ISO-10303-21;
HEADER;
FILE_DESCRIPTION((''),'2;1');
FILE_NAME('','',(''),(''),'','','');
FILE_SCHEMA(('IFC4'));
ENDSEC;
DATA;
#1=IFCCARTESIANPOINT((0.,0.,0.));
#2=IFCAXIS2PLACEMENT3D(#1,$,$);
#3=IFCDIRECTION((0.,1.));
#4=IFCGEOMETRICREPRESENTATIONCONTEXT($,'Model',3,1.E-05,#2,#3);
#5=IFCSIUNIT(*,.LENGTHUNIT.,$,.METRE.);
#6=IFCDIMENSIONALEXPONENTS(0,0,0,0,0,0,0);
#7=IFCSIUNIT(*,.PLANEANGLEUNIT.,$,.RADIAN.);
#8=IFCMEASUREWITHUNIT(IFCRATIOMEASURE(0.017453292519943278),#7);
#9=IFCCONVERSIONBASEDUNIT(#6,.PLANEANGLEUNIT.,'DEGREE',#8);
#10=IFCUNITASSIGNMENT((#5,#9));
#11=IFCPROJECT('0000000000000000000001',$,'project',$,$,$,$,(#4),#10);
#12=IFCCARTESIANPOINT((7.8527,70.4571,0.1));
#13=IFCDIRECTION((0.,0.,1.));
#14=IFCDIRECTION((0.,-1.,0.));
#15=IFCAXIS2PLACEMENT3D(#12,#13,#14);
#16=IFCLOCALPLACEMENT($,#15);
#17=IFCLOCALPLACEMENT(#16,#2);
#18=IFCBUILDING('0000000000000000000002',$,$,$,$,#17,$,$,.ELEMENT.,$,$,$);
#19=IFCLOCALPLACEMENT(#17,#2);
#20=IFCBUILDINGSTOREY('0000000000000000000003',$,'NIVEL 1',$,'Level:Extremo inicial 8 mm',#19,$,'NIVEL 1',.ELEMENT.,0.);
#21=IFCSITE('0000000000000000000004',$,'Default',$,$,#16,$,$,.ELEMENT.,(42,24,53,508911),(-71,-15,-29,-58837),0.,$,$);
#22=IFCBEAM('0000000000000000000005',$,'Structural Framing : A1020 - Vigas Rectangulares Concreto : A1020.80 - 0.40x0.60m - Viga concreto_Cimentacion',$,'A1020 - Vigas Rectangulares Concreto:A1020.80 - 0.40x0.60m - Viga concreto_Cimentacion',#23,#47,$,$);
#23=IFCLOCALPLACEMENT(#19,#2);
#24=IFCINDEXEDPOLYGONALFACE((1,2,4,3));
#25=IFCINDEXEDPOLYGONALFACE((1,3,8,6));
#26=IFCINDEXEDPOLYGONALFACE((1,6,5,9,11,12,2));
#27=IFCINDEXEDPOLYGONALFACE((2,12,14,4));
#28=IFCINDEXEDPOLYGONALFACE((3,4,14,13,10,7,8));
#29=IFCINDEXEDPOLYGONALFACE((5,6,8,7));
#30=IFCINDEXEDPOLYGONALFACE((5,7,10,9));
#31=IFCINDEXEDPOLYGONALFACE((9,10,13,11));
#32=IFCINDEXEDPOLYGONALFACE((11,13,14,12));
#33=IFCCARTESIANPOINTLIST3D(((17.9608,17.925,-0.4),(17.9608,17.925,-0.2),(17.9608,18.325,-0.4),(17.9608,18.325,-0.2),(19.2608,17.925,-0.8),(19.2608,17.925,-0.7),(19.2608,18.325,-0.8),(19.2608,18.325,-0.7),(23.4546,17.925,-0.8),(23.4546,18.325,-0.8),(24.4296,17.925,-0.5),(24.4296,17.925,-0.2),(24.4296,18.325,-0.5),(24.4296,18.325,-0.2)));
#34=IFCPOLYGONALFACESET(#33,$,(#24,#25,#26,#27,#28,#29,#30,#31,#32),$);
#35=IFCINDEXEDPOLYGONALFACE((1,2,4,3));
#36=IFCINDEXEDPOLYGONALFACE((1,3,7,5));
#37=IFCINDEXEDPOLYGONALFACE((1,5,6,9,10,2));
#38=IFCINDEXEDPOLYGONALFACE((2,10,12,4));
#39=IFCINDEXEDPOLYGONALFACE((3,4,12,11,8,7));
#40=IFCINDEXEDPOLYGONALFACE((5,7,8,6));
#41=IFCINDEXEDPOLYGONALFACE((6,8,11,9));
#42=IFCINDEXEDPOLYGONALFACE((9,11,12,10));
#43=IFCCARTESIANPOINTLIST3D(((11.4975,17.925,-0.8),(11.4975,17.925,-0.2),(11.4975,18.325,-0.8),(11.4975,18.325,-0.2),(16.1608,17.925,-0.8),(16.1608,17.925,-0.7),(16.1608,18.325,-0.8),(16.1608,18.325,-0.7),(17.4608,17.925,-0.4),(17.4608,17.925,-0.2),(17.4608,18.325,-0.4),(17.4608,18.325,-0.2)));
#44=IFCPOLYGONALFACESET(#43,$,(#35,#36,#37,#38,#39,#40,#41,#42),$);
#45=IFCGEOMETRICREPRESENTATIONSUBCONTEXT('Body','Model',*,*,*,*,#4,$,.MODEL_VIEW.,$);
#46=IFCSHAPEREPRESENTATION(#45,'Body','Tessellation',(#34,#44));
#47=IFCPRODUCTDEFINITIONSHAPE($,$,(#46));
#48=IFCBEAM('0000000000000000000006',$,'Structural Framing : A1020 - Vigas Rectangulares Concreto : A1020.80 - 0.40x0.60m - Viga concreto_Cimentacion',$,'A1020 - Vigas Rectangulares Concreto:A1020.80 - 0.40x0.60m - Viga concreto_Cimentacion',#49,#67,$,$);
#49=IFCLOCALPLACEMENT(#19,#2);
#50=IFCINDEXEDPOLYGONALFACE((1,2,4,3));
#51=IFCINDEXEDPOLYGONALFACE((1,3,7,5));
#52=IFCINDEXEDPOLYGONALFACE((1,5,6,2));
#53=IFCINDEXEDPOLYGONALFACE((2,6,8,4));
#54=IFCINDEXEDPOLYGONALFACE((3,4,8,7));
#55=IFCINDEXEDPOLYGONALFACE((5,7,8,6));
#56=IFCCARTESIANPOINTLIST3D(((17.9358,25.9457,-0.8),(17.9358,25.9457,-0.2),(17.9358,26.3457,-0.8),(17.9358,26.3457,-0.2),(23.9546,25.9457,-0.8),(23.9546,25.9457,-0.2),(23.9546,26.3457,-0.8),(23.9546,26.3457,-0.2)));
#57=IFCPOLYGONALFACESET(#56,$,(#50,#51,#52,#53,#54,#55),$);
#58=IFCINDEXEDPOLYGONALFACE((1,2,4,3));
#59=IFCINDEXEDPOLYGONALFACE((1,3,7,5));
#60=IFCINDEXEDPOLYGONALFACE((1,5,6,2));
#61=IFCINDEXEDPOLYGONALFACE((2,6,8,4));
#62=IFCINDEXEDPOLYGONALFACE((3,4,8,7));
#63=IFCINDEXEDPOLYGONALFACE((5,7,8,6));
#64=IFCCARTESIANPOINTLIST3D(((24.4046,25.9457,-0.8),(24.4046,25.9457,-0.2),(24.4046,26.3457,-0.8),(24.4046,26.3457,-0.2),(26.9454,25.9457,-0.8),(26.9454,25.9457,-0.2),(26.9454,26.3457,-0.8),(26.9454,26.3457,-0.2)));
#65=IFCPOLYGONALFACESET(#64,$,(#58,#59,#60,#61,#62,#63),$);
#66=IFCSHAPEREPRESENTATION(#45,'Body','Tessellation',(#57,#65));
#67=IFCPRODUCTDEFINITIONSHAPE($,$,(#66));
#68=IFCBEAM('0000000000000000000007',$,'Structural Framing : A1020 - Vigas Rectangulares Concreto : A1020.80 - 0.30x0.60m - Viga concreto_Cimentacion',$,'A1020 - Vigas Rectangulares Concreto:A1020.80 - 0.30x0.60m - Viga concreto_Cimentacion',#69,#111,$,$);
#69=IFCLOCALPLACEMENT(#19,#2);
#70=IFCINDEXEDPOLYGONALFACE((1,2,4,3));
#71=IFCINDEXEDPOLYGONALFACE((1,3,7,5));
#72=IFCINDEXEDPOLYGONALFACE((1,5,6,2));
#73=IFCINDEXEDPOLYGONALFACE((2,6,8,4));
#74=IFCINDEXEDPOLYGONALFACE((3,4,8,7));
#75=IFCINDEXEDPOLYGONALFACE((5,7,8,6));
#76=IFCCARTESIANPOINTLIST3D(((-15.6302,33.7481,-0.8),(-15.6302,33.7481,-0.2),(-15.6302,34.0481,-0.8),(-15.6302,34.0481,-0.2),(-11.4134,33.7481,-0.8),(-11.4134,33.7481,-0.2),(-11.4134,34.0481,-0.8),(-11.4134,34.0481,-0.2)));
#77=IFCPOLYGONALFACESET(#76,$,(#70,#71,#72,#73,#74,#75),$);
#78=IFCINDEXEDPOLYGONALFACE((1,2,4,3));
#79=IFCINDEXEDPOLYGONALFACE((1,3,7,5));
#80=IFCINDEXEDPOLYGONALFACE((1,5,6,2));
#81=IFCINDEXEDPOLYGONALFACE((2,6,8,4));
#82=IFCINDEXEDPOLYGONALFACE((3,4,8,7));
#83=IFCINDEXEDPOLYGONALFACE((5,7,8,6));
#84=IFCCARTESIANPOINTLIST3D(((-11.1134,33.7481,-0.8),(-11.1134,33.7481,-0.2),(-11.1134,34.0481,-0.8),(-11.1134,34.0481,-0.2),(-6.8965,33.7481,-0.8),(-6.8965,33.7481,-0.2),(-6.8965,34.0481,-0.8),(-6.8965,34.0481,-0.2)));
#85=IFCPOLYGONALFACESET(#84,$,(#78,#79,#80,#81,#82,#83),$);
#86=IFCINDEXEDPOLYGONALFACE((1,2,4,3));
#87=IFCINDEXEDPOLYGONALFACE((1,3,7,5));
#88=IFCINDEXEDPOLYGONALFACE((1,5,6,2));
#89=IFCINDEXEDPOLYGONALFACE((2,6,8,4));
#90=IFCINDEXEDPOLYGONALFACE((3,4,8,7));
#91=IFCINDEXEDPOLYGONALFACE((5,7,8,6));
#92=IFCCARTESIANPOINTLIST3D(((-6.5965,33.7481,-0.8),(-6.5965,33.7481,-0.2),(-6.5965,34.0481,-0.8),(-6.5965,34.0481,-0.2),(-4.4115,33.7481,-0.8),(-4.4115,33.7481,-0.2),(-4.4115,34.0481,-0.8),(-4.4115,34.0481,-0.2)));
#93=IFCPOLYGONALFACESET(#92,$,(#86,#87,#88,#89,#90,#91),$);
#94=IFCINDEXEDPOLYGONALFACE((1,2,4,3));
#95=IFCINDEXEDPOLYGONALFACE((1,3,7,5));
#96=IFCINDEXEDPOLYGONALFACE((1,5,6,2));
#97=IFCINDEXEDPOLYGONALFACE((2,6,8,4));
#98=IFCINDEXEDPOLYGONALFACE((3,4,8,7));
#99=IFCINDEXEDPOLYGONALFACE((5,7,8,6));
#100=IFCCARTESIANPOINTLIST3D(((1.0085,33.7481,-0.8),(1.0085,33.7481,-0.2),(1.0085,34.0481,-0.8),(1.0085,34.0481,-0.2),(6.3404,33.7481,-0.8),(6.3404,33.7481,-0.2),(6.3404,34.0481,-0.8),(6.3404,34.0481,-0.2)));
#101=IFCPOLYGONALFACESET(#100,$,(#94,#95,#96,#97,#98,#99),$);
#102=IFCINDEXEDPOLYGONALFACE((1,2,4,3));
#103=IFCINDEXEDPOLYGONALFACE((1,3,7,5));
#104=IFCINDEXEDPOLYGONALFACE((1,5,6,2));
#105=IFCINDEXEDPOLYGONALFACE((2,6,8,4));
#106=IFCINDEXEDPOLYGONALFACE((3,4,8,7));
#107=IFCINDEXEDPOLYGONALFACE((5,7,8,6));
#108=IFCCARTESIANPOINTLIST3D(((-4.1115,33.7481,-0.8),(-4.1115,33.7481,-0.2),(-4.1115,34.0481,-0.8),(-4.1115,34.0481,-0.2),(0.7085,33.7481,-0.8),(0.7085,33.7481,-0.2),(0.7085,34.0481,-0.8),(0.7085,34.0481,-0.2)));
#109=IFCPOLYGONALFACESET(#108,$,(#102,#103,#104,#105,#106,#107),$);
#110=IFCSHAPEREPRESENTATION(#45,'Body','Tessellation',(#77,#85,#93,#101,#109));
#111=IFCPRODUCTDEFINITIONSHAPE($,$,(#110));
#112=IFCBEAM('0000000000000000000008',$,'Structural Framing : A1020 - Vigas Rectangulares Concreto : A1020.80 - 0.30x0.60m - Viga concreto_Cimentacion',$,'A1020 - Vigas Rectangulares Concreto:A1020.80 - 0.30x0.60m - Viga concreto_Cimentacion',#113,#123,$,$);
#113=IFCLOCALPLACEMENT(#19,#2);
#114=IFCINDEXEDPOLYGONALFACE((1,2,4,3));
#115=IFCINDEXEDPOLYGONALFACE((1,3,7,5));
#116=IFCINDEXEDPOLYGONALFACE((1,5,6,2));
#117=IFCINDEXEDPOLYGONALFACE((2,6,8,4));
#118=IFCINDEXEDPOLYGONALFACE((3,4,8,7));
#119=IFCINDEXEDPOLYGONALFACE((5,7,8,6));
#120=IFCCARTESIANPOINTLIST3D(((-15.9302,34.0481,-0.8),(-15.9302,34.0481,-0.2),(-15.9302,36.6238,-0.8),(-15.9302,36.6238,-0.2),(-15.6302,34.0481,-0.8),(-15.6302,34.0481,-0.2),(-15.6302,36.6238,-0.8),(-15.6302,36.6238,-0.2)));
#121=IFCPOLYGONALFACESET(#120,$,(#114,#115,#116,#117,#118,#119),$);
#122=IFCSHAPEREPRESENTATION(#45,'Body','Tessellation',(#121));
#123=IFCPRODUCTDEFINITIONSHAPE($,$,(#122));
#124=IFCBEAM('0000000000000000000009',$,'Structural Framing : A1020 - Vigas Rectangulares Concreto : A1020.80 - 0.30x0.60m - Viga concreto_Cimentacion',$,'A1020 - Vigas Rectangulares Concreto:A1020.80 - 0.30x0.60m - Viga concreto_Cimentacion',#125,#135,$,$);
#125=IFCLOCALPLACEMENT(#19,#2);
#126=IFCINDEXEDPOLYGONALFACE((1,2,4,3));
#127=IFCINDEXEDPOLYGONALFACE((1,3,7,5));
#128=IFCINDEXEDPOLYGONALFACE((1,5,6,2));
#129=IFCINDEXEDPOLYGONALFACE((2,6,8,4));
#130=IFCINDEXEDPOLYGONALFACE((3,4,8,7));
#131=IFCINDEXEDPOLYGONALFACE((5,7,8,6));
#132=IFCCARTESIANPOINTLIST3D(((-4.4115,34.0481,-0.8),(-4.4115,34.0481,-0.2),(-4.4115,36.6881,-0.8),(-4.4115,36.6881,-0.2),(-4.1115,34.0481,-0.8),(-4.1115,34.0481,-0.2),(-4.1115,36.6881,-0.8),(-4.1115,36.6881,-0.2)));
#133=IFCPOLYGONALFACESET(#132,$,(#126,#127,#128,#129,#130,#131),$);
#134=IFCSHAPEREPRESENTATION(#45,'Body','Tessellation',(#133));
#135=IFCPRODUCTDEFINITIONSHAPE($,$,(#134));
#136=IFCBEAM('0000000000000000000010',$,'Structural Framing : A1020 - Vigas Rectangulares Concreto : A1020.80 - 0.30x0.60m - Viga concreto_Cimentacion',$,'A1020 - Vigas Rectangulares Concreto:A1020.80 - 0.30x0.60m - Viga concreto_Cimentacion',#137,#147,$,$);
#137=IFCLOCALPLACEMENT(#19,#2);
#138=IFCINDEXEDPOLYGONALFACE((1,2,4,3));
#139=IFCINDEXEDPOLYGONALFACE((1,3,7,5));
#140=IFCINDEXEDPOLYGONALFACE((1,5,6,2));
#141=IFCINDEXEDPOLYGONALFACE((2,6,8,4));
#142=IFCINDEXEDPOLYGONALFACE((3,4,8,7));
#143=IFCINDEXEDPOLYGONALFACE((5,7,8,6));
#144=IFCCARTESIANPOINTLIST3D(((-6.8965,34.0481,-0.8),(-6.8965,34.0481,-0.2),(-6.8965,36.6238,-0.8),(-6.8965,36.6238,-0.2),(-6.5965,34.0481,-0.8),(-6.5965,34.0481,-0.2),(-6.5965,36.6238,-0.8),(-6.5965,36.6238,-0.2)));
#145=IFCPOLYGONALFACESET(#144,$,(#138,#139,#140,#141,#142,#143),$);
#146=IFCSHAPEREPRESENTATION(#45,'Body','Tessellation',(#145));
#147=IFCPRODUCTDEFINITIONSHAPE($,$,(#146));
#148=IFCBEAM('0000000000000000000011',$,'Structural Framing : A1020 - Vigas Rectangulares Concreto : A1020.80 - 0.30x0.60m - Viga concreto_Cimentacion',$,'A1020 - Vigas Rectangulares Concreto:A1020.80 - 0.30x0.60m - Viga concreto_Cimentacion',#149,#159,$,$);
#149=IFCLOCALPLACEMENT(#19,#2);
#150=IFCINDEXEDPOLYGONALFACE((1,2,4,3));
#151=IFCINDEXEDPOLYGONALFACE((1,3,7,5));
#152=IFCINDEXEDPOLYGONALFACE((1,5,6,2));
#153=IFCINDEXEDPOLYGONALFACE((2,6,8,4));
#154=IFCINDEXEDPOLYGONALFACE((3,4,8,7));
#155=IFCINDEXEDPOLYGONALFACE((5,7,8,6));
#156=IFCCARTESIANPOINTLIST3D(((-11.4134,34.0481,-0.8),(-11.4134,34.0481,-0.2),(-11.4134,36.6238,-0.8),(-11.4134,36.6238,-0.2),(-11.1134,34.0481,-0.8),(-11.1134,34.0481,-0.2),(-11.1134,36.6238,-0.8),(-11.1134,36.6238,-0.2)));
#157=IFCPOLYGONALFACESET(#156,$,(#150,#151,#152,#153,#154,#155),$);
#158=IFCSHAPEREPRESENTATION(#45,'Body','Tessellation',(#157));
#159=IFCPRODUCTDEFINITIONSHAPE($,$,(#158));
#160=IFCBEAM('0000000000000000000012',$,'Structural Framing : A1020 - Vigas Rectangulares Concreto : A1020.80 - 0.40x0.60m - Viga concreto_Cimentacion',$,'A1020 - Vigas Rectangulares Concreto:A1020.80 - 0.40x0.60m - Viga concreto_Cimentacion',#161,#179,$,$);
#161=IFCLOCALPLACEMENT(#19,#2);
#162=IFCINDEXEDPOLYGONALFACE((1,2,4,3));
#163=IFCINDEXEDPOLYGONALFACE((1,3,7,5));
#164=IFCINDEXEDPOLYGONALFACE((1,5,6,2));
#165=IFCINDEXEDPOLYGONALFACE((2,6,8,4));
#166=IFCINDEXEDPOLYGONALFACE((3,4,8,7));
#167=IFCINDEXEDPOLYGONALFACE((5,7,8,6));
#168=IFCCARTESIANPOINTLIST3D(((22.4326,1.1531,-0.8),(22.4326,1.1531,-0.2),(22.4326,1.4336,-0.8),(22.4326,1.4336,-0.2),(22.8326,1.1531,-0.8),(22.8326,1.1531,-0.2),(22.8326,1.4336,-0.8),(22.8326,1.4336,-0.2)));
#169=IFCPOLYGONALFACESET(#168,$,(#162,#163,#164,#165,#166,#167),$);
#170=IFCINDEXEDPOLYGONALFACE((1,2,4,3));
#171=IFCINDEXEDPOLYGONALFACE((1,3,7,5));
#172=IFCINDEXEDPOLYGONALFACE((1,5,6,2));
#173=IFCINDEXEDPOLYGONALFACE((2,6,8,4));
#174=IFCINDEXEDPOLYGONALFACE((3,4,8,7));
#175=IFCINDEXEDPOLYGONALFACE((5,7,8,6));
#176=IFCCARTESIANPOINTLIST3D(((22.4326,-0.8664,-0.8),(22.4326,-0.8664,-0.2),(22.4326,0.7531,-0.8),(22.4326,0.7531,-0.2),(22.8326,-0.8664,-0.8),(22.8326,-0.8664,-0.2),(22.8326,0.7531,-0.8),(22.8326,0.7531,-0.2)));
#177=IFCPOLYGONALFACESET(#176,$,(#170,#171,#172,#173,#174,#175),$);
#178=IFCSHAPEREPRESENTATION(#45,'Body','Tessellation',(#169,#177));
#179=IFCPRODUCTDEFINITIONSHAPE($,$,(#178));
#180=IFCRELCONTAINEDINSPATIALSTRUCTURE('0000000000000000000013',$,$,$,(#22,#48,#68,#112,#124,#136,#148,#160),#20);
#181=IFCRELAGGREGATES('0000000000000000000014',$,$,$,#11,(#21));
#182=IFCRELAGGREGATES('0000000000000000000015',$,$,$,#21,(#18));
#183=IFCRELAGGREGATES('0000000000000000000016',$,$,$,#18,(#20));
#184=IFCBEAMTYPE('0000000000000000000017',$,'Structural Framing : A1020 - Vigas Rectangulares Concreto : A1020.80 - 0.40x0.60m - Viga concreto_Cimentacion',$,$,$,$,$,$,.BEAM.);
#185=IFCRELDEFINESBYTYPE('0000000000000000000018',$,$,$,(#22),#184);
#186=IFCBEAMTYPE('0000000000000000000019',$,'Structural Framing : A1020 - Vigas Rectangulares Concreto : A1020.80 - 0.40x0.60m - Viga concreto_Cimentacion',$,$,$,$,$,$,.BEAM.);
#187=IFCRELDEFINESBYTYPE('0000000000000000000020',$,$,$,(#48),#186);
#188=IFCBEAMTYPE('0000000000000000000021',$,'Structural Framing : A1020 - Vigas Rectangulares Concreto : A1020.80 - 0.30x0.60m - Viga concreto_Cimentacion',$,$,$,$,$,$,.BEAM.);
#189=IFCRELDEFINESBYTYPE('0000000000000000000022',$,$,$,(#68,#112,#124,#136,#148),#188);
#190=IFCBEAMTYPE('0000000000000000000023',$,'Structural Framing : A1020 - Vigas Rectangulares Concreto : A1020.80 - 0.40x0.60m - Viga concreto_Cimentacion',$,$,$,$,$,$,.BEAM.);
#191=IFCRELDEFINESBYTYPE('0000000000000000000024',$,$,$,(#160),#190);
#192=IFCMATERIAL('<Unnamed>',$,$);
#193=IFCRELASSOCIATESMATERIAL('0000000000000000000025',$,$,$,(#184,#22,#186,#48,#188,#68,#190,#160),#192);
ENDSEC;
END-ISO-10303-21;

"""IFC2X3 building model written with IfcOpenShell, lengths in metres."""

from ifc_helpers import new_model, entity, si_unit, converted_unit, direction, frame, frame_2d, origin, place, context, subcontext, project, spatial, polyline, rectangle, extrude, clip, halfspace, bounded_halfspace, source, transform, mapped, material, type_object, type_shapes, element, save


model = new_model("IFC2X3")

# Units and contexts
model_context = context("Model", 3, precision=1e-05, world=origin(), true_north=direction((0.0, 1.0)))
body_context = subcontext(model_context, "Body", "Model", "MODEL_VIEW")
ifc_project = project(units=[si_unit("LENGTHUNIT", "METRE"), converted_unit("PLANEANGLEUNIT", "DEGREE", entity("IfcRatioMeasure", 0.017453292519943278), si_unit("PLANEANGLEUNIT", "RADIAN"), dimensions=[0, 0, 0, 0, 0, 0, 0])], contexts=[model_context])

# Site, building, storey
site_placement = place(None, frame((7.8527, 70.4571, 0.1), z_axis=(0.0, 0.0, 1.0), x_axis=(0.0, -1.0, 0.0)))
site = spatial("IfcSite", under=ifc_project, at=site_placement, Name="Default", CompositionType="ELEMENT", RefLatitude=(42, 24, 53, 508911), RefLongitude=(-71, -15, -29, -58837), RefElevation=0.0)
building_placement = place(site_placement, origin())
building = spatial("IfcBuilding", under=site, at=building_placement, CompositionType="ELEMENT")
storey_placement = place(building_placement, origin())
storey = spatial("IfcBuildingStorey", under=building, at=storey_placement, Name="NIVEL 1", ObjectType="Level:Extremo inicial 8 mm", LongName="NIVEL 1", CompositionType="ELEMENT", Elevation=0.0)

# Shared definitions
ifc_material_1 = material(Name="<Unnamed>")

# Beams
beam_type_1 = type_object("IfcBeamType", Name="Structural Framing : A1020 - Vigas Rectangulares Concreto : A1020.80 - 0.40x0.60m - Viga concreto_Cimentacion", PredefinedType="BEAM", material=ifc_material_1)
shared_shape_1 = source(origin(), body_context, "Body", "SweptSolid", [
    clip(clip(clip(extrude(rectangle(XDim=0.6, YDim=0.4, at=frame_2d((0.0, 0.0), x_axis=(0.0, 1.0))), frame((17.9608, 18.125, -0.5), z_axis=(1.0, 0.0, 0.0), x_axis=(0.0, 1.0, 0.0)), (0.0, 0.0, 1.0), 6.4688), halfspace(frame((23.4546, 18.125, -0.8), z_axis=(0.294086, 0.0, -0.955779), x_axis=(0.0, -1.0, 0.0)), False)), bounded_halfspace(frame((19.2608, 18.125, -0.7), z_axis=(-0.22486, 0.0, -0.974391), x_axis=(0.0, 1.0, 0.0)), False, frame((17.9608, 18.125, -0.5), z_axis=(1.0, 0.0, 0.0), x_axis=(0.0, 1.0, 0.0)), polyline([(-0.2, -0.2), (-0.2, 0.1), (0.2, 0.1), (0.2, -0.2), (-0.2, -0.2)]))), bounded_halfspace(frame((19.2608, 16.575, -0.7), z_axis=(-1.0, 0.0, 0.0), x_axis=(0.0, 0.0, -1.0)), False, frame((17.9608, 18.125, -0.5), z_axis=(1.0, 0.0, 0.0), x_axis=(0.0, 1.0, 0.0)), polyline([(-0.2, -0.3), (-0.2, -0.2), (0.2, -0.2), (0.2, -0.3), (-0.2, -0.3)]))),
    clip(clip(extrude(rectangle(XDim=0.6, YDim=0.4, at=frame_2d((0.0, 0.0), x_axis=(0.0, 1.0))), frame((11.4975, 18.125, -0.5), z_axis=(1.0, 0.0, 0.0), x_axis=(0.0, 1.0, 0.0)), (0.0, 0.0, 1.0), 5.9633), bounded_halfspace(frame((16.1608, 18.125, -0.7), z_axis=(0.22486, 0.0, -0.974391), x_axis=(0.0, -1.0, 0.0)), False, frame((11.4975, 18.125, -0.5), z_axis=(1.0, 0.0, 0.0), x_axis=(0.0, 1.0, 0.0)), polyline([(-0.2, 0.1), (-0.2, -0.2), (0.2, -0.2), (0.2, 0.1), (-0.2, 0.1)]))), bounded_halfspace(frame((16.1608, 19.675, -0.7), z_axis=(1.0, 0.0, 0.0), x_axis=(0.0, 0.0, -1.0)), False, frame((11.4975, 18.125, -0.5), z_axis=(1.0, 0.0, 0.0), x_axis=(0.0, 1.0, 0.0)), polyline([(-0.2, -0.2), (-0.2, -0.3), (0.2, -0.3), (0.2, -0.2), (-0.2, -0.2)]))),
])
type_shapes(beam_type_1, [shared_shape_1])
beam_1_placement = place(storey_placement, origin())
element("IfcBeam", 1, at=beam_1_placement, inside=storey, type_object=beam_type_1, material=ifc_material_1, Name="Structural Framing : A1020 - Vigas Rectangulares Concreto : A1020.80 - 0.40x0.60m - Viga concreto_Cimentacion", ObjectType="A1020 - Vigas Rectangulares Concreto:A1020.80 - 0.40x0.60m - Viga concreto_Cimentacion", context=body_context, shape_type="MappedRepresentation", body=[
    mapped(shared_shape_1, transform((0.0, 0.0, 0.0), scale=1.0)),
])
beam_type_2 = type_object("IfcBeamType", Name="Structural Framing : A1020 - Vigas Rectangulares Concreto : A1020.80 - 0.40x0.60m - Viga concreto_Cimentacion", PredefinedType="BEAM", material=ifc_material_1)
shared_shape_2 = source(origin(), body_context, "Body", "SweptSolid", [
    extrude(rectangle(XDim=0.6, YDim=0.4, at=frame_2d((0.0, 0.0), x_axis=(1.0, 0.0))), frame((17.9358, 26.1457, -0.5), z_axis=(1.0, 0.0, 0.0), x_axis=(0.0, 0.0, -1.0)), (0.0, 0.0, 1.0), 6.0188),
    extrude(rectangle(XDim=0.6, YDim=0.4, at=frame_2d((0.0, 0.0), x_axis=(1.0, 0.0))), frame((24.4046, 26.1457, -0.5), z_axis=(1.0, 0.0, 0.0), x_axis=(0.0, 0.0, -1.0)), (0.0, 0.0, 1.0), 2.5408),
])
type_shapes(beam_type_2, [shared_shape_2])
beam_2_placement = place(storey_placement, origin())
element("IfcBeam", 2, at=beam_2_placement, inside=storey, type_object=beam_type_2, material=ifc_material_1, Name="Structural Framing : A1020 - Vigas Rectangulares Concreto : A1020.80 - 0.40x0.60m - Viga concreto_Cimentacion", ObjectType="A1020 - Vigas Rectangulares Concreto:A1020.80 - 0.40x0.60m - Viga concreto_Cimentacion", context=body_context, shape_type="MappedRepresentation", body=[
    mapped(shared_shape_2, transform((0.0, 0.0, 0.0), scale=1.0)),
])
beam_type_3 = type_object("IfcBeamType", Name="Structural Framing : A1020 - Vigas Rectangulares Concreto : A1020.80 - 0.30x0.60m - Viga concreto_Cimentacion", PredefinedType="BEAM", material=ifc_material_1)
shared_shape_3 = source(origin(), body_context, "Body", "SweptSolid", [
    extrude(rectangle(XDim=0.6, YDim=0.3, at=frame_2d((0.0, 0.0), x_axis=(1.0, 0.0))), frame((-15.6302, 33.8981, -0.5), z_axis=(1.0, 0.0, 0.0), x_axis=(0.0, 0.0, -1.0)), (0.0, 0.0, 1.0), 4.2168),
    extrude(rectangle(XDim=0.6, YDim=0.3, at=frame_2d((0.0, 0.0), x_axis=(1.0, 0.0))), frame((-11.1134, 33.8981, -0.5), z_axis=(1.0, 0.0, 0.0), x_axis=(0.0, 0.0, -1.0)), (0.0, 0.0, 1.0), 4.2168),
    extrude(rectangle(XDim=0.6, YDim=0.3, at=frame_2d((0.0, 0.0), x_axis=(1.0, 0.0))), frame((-6.5965, 33.8981, -0.5), z_axis=(1.0, 0.0, 0.0), x_axis=(0.0, 0.0, -1.0)), (0.0, 0.0, 1.0), 2.185),
    extrude(rectangle(XDim=0.6, YDim=0.3, at=frame_2d((0.0, 0.0), x_axis=(1.0, 0.0))), frame((1.0085, 33.8981, -0.5), z_axis=(1.0, 0.0, 0.0), x_axis=(0.0, 0.0, -1.0)), (0.0, 0.0, 1.0), 5.3319),
    extrude(rectangle(XDim=0.6, YDim=0.3, at=frame_2d((0.0, 0.0), x_axis=(1.0, 0.0))), frame((-4.1115, 33.8981, -0.5), z_axis=(1.0, 0.0, 0.0), x_axis=(0.0, 0.0, -1.0)), (0.0, 0.0, 1.0), 4.82),
])
type_shapes(beam_type_3, [shared_shape_3])
beam_3_placement = place(storey_placement, origin())
element("IfcBeam", 3, at=beam_3_placement, inside=storey, type_object=beam_type_3, material=ifc_material_1, Name="Structural Framing : A1020 - Vigas Rectangulares Concreto : A1020.80 - 0.30x0.60m - Viga concreto_Cimentacion", ObjectType="A1020 - Vigas Rectangulares Concreto:A1020.80 - 0.30x0.60m - Viga concreto_Cimentacion", context=body_context, shape_type="MappedRepresentation", body=[
    mapped(shared_shape_3, transform((0.0, 0.0, 0.0), scale=1.0)),
])
beam_4_placement = place(storey_placement, frame((-15.7802, 33.8981, 0.0), z_axis=(0.0, 0.0, 1.0), x_axis=(0.0, 1.0, 0.0)))
element("IfcBeam", 4, at=beam_4_placement, inside=storey, type_object=beam_type_3, Name="Structural Framing : A1020 - Vigas Rectangulares Concreto : A1020.80 - 0.30x0.60m - Viga concreto_Cimentacion", ObjectType="A1020 - Vigas Rectangulares Concreto:A1020.80 - 0.30x0.60m - Viga concreto_Cimentacion", context=body_context, shape_type="SweptSolid", body=[
    extrude(rectangle(XDim=0.6, YDim=0.3, at=frame_2d((0.0, 0.0), x_axis=(1.0, 0.0))), frame((0.15, 0.0, -0.5), z_axis=(1.0, 0.0, 0.0), x_axis=(0.0, 0.0, -1.0)), (0.0, 0.0, 1.0), 2.5757),
])
beam_5_placement = place(storey_placement, frame((-4.2615, 33.8981, 0.0), z_axis=(0.0, 0.0, 1.0), x_axis=(0.0, 1.0, 0.0)))
element("IfcBeam", 5, at=beam_5_placement, inside=storey, type_object=beam_type_3, Name="Structural Framing : A1020 - Vigas Rectangulares Concreto : A1020.80 - 0.30x0.60m - Viga concreto_Cimentacion", ObjectType="A1020 - Vigas Rectangulares Concreto:A1020.80 - 0.30x0.60m - Viga concreto_Cimentacion", context=body_context, shape_type="SweptSolid", body=[
    extrude(rectangle(XDim=0.6, YDim=0.3, at=frame_2d((0.0, 0.0), x_axis=(1.0, 0.0))), frame((0.15, 0.0, -0.5), z_axis=(1.0, 0.0, 0.0), x_axis=(0.0, 0.0, -1.0)), (0.0, 0.0, 1.0), 2.6399),
])
beam_6_placement = place(storey_placement, frame((-6.7465, 33.8981, 0.0), z_axis=(0.0, 0.0, 1.0), x_axis=(0.0, 1.0, 0.0)))
element("IfcBeam", 6, at=beam_6_placement, inside=storey, type_object=beam_type_3, Name="Structural Framing : A1020 - Vigas Rectangulares Concreto : A1020.80 - 0.30x0.60m - Viga concreto_Cimentacion", ObjectType="A1020 - Vigas Rectangulares Concreto:A1020.80 - 0.30x0.60m - Viga concreto_Cimentacion", context=body_context, shape_type="SweptSolid", body=[
    extrude(rectangle(XDim=0.6, YDim=0.3, at=frame_2d((0.0, 0.0), x_axis=(1.0, 0.0))), frame((0.15, 0.0, -0.5), z_axis=(1.0, 0.0, 0.0), x_axis=(0.0, 0.0, -1.0)), (0.0, 0.0, 1.0), 2.5757),
])
beam_7_placement = place(storey_placement, frame((-11.2634, 33.8981, 0.0), z_axis=(0.0, 0.0, 1.0), x_axis=(0.0, 1.0, 0.0)))
element("IfcBeam", 7, at=beam_7_placement, inside=storey, type_object=beam_type_3, Name="Structural Framing : A1020 - Vigas Rectangulares Concreto : A1020.80 - 0.30x0.60m - Viga concreto_Cimentacion", ObjectType="A1020 - Vigas Rectangulares Concreto:A1020.80 - 0.30x0.60m - Viga concreto_Cimentacion", context=body_context, shape_type="SweptSolid", body=[
    extrude(rectangle(XDim=0.6, YDim=0.3, at=frame_2d((0.0, 0.0), x_axis=(1.0, 0.0))), frame((0.15, 0.0, -0.5), z_axis=(1.0, 0.0, 0.0), x_axis=(0.0, 0.0, -1.0)), (0.0, 0.0, 1.0), 2.5757),
])
beam_type_4 = type_object("IfcBeamType", Name="Structural Framing : A1020 - Vigas Rectangulares Concreto : A1020.80 - 0.40x0.60m - Viga concreto_Cimentacion", PredefinedType="BEAM", material=ifc_material_1)
shared_shape_4 = source(origin(), body_context, "Body", "SweptSolid", [
    extrude(rectangle(XDim=0.6, YDim=0.4, at=frame_2d((0.0, 0.0), x_axis=(0.0, 1.0))), frame((22.6326, 1.1531, -0.5), z_axis=(0.0, 1.0, 0.0), x_axis=(-1.0, 0.0, 0.0)), (0.0, 0.0, 1.0), 0.2805),
    extrude(rectangle(XDim=0.6, YDim=0.4, at=frame_2d((0.0, 0.0), x_axis=(0.0, 1.0))), frame((22.6326, -0.8664, -0.5), z_axis=(0.0, 1.0, 0.0), x_axis=(-1.0, 0.0, 0.0)), (0.0, 0.0, 1.0), 1.6195),
])
type_shapes(beam_type_4, [shared_shape_4])
beam_8_placement = place(storey_placement, origin())
element("IfcBeam", 8, at=beam_8_placement, inside=storey, type_object=beam_type_4, material=ifc_material_1, Name="Structural Framing : A1020 - Vigas Rectangulares Concreto : A1020.80 - 0.40x0.60m - Viga concreto_Cimentacion", ObjectType="A1020 - Vigas Rectangulares Concreto:A1020.80 - 0.40x0.60m - Viga concreto_Cimentacion", context=body_context, shape_type="MappedRepresentation", body=[
    mapped(shared_shape_4, transform((0.0, 0.0, 0.0), scale=1.0)),
])

save(model, "model.ifc")
